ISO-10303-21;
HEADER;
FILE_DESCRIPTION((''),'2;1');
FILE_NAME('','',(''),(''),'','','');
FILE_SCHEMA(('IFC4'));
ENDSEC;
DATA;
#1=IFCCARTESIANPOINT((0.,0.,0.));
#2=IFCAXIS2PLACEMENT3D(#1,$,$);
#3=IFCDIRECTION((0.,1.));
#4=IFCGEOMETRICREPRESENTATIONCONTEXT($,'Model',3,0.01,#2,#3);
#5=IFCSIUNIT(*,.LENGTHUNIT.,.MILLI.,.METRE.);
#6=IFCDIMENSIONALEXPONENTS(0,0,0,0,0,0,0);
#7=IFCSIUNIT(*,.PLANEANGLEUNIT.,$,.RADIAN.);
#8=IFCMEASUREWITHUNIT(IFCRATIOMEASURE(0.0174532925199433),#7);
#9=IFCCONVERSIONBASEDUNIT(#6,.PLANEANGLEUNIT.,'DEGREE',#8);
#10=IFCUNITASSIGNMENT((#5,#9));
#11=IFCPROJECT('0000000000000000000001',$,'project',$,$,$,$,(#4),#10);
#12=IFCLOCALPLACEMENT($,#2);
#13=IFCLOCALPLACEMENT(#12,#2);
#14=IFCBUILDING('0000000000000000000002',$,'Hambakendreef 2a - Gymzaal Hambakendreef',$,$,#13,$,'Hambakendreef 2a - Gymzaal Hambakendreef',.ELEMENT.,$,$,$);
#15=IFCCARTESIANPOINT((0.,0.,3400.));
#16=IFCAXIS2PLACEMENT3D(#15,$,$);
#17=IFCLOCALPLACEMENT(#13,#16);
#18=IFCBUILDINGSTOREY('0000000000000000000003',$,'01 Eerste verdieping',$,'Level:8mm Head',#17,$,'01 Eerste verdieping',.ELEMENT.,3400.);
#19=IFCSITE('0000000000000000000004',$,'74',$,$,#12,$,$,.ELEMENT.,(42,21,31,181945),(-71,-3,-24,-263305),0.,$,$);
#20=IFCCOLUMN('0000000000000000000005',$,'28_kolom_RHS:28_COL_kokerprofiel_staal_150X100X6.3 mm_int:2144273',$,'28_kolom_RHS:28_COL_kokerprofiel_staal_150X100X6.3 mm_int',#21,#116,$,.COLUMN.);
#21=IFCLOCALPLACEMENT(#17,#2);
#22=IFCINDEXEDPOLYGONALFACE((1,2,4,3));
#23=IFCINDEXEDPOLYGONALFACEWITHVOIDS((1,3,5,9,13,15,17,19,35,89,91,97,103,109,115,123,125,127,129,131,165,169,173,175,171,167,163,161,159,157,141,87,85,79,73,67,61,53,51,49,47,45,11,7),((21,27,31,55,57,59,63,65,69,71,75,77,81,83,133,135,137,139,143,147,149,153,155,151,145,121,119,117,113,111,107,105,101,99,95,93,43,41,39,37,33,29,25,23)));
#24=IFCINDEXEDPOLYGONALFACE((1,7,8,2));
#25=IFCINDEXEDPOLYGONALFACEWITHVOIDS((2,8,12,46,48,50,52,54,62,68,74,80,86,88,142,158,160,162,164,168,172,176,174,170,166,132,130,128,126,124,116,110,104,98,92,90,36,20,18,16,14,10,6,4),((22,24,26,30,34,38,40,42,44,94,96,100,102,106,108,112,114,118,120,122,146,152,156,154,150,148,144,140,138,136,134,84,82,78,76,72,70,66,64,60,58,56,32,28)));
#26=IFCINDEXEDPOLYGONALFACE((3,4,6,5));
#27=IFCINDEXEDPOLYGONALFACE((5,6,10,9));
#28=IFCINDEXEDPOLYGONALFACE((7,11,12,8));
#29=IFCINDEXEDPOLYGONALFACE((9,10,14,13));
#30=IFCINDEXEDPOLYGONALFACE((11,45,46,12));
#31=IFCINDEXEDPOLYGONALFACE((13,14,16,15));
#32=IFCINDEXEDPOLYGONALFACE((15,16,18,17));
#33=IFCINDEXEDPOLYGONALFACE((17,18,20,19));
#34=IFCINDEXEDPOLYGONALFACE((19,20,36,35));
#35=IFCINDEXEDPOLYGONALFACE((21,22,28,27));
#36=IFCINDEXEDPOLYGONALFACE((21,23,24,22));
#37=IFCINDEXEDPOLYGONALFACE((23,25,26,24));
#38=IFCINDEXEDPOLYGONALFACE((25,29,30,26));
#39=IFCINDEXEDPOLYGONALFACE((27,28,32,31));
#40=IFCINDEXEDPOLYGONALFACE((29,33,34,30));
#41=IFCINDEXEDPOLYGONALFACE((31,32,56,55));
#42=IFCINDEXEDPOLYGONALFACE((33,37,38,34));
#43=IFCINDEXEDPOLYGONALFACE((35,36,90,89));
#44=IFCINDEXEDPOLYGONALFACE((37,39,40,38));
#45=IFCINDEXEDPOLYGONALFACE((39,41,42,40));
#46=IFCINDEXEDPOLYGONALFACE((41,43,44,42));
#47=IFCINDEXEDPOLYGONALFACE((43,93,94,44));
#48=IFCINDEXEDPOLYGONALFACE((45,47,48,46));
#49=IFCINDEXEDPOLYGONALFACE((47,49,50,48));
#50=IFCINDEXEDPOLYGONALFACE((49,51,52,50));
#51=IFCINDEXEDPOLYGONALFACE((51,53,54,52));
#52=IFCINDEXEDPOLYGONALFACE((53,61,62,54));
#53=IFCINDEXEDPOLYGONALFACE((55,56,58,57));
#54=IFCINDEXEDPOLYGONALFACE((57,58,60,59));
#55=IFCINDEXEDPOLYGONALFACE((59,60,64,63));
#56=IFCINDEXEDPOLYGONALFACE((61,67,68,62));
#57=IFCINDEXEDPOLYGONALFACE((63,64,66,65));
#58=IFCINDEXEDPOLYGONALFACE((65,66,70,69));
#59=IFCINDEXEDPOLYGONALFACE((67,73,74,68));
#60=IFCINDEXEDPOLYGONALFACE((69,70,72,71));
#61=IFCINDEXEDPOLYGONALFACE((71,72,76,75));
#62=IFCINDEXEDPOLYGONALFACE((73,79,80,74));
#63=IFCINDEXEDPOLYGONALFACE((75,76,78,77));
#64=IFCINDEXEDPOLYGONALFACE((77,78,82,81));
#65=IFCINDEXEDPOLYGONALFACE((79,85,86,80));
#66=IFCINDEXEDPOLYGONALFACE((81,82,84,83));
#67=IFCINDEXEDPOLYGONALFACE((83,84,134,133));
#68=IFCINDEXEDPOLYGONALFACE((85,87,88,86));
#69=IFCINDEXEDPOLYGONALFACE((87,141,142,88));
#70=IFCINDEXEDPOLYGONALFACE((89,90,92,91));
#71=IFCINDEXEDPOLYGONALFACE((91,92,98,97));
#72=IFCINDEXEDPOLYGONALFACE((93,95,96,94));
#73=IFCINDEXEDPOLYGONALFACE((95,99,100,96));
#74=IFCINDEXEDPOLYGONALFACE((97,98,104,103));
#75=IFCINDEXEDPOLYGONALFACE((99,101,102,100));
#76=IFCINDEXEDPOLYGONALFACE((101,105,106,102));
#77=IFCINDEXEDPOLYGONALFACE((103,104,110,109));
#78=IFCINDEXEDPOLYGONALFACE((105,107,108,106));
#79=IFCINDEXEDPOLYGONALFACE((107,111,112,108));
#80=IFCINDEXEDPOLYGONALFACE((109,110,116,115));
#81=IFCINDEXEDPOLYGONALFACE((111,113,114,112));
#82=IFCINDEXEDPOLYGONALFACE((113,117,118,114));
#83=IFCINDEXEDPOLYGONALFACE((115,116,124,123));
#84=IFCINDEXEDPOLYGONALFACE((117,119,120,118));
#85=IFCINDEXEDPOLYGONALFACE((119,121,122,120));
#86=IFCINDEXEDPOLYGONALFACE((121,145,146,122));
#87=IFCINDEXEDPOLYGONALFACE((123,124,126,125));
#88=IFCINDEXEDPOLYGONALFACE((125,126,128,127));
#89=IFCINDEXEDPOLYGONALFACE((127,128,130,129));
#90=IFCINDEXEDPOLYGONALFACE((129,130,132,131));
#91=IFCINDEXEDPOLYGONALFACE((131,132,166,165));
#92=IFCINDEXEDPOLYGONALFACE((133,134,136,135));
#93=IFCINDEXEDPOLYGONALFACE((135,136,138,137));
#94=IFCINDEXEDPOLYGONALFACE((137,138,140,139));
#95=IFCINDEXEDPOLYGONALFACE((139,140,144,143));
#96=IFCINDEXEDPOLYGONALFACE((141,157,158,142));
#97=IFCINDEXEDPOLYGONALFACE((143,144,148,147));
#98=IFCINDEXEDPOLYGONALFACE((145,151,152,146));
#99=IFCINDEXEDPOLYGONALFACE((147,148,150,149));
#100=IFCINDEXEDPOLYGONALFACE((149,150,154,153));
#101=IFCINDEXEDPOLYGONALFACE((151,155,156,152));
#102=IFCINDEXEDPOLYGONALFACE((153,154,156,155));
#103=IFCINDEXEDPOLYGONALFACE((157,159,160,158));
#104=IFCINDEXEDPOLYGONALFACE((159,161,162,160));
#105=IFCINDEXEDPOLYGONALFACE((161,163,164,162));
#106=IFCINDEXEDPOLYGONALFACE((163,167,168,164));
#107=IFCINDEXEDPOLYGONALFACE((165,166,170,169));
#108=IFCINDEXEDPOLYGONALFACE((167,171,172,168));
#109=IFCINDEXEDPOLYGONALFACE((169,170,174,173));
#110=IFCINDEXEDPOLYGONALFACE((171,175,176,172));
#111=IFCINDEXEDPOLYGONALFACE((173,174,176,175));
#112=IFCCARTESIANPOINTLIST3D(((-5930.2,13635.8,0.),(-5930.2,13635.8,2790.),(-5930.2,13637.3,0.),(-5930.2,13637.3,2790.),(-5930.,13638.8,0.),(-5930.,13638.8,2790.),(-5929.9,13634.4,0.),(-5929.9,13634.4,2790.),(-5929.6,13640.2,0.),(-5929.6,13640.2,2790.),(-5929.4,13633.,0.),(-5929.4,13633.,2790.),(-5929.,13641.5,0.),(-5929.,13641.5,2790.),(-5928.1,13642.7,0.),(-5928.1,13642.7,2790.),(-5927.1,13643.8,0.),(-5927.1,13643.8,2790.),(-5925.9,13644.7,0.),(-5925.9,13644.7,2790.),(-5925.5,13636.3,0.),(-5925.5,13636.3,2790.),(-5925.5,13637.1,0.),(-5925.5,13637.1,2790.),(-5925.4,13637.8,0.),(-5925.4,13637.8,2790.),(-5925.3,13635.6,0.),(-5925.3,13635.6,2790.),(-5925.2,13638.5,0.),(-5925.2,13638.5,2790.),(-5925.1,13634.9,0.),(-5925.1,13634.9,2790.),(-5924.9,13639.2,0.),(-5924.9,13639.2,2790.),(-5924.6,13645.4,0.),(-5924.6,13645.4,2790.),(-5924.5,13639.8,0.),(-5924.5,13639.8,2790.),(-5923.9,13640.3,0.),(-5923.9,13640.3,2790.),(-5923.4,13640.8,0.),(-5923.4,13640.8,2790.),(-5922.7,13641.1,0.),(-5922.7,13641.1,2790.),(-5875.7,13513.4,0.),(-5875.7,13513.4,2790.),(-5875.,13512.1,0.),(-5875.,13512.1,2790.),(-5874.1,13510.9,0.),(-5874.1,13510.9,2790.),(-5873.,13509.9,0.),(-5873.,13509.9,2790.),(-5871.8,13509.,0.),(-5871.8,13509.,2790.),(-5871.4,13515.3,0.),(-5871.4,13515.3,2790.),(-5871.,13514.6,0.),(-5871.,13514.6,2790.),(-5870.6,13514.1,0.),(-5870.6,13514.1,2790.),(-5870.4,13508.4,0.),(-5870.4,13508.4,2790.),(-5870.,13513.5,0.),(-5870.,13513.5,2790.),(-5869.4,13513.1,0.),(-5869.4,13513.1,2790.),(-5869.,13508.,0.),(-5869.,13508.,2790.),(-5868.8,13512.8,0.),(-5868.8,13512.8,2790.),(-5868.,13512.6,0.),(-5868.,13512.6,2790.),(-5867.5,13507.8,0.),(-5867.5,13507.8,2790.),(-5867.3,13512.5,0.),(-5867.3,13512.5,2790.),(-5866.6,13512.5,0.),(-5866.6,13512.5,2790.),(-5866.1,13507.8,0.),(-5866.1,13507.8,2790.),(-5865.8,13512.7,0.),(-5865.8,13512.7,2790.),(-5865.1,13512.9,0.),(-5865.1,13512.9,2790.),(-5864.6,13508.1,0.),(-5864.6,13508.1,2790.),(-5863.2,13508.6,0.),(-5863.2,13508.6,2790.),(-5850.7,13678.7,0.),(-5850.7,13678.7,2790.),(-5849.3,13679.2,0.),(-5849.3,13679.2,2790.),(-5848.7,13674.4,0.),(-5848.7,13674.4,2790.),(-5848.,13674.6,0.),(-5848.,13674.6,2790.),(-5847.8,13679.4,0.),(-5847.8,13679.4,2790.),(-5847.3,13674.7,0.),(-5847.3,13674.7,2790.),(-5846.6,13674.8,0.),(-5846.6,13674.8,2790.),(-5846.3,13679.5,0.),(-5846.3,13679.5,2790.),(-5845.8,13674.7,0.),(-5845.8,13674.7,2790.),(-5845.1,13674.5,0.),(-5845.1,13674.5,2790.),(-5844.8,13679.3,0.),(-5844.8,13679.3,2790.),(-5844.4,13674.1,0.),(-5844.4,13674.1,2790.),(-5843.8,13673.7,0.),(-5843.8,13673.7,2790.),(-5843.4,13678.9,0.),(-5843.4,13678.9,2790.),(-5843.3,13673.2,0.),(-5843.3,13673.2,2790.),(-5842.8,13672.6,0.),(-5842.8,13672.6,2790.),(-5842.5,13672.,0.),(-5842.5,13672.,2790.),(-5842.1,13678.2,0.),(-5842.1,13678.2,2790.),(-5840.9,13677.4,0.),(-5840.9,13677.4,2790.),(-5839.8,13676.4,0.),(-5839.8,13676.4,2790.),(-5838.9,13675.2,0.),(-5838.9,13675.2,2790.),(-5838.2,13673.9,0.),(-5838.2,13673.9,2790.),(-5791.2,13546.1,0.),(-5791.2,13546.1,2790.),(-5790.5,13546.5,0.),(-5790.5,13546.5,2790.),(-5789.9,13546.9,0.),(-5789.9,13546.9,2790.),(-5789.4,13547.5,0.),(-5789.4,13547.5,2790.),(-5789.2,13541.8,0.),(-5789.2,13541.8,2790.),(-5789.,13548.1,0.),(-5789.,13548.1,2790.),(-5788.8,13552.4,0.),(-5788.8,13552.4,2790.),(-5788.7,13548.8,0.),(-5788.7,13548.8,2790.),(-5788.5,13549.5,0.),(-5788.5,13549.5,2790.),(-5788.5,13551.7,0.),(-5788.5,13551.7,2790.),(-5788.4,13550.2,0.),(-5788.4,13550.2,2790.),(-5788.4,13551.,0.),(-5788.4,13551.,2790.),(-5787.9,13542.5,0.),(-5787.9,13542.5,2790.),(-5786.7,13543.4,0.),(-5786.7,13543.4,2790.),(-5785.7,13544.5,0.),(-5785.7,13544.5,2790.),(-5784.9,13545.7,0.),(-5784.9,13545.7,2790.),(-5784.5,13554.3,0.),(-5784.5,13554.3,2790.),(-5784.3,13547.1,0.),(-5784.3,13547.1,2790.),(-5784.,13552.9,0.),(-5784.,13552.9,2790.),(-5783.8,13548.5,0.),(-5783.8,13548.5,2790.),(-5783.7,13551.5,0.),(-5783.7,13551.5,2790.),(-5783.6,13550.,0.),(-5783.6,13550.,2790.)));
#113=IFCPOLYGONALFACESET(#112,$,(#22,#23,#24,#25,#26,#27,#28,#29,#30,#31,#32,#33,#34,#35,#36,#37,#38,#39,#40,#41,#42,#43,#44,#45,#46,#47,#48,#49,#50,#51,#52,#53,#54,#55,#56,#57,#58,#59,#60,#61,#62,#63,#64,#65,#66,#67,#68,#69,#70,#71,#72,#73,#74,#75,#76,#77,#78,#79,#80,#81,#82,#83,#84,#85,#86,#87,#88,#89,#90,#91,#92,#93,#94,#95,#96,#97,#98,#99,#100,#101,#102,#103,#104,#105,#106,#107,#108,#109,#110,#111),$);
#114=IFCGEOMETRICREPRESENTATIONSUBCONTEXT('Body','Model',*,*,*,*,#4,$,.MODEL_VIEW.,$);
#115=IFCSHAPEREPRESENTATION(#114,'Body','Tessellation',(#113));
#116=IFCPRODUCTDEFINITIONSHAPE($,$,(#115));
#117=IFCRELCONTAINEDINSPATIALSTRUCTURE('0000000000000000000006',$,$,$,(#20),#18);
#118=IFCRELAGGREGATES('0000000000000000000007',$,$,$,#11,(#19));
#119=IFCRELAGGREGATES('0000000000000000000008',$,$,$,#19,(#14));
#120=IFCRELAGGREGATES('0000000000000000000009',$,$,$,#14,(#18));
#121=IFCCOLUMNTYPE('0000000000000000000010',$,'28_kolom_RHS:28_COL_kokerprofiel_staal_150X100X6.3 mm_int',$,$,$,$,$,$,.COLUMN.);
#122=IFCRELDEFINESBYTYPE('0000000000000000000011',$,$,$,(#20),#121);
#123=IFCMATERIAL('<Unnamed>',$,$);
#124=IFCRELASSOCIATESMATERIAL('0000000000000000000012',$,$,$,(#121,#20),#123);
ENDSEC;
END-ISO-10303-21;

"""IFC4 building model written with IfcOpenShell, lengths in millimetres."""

from ifc_helpers import new_model, entity, si_unit, converted_unit, direction, frame, origin, place, context, subcontext, project, spatial, indexed_curve, outline, extrude, source, transform, mapped, material, type_object, type_shapes, element, save


model = new_model("IFC4")

# Units and contexts
model_context = context("Model", 3, precision=0.01, world=origin(), true_north=direction((0.0, 1.0)))
body_context = subcontext(model_context, "Body", "Model", "MODEL_VIEW")
ifc_project = project(units=[si_unit("LENGTHUNIT", "METRE", prefix="MILLI"), converted_unit("PLANEANGLEUNIT", "DEGREE", entity("IfcRatioMeasure", 0.0174532925199433), si_unit("PLANEANGLEUNIT", "RADIAN"), dimensions=[0, 0, 0, 0, 0, 0, 0])], contexts=[model_context])

# Site, building, storey
site_placement = place(None, origin())
site = spatial("IfcSite", under=ifc_project, at=site_placement, Name="74", CompositionType="ELEMENT", RefLatitude=(42, 21, 31, 181945), RefLongitude=(-71, -3, -24, -263305), RefElevation=0.0)
building_placement = place(site_placement, origin())
building = spatial("IfcBuilding", under=site, at=building_placement, Name="Hambakendreef 2a - Gymzaal Hambakendreef", LongName="Hambakendreef 2a - Gymzaal Hambakendreef", CompositionType="ELEMENT")
storey_placement = place(building_placement, frame((0.0, 0.0, 3400.0)))
storey = spatial("IfcBuildingStorey", under=building, at=storey_placement, Name="01 Eerste verdieping", ObjectType="Level:8mm Head", LongName="01 Eerste verdieping", CompositionType="ELEMENT", Elevation=3400.0)

# Column
ifc_material_1 = material(Name="<Unnamed>")
column_type_1 = type_object("IfcColumnType", Name="28_kolom_RHS:28_COL_kokerprofiel_staal_150X100X6.3 mm_int", PredefinedType="COLUMN", material=ifc_material_1)
shared_shape_1 = source(origin(), body_context, "Body", "SweptSolid", [
    extrude(outline(indexed_curve([(-40.5, -75.0), (40.5, -75.0), (42.0, -74.9), (43.5, -74.5), (44.8, -74.0), (46.1, -73.2), (47.2, -72.2), (48.2, -71.1), (49.0, -69.8), (49.5, -68.5), (49.9, -67.0), (50.0, -65.6), (50.0, 65.6), (49.9, 67.0), (49.5, 68.5), (49.0, 69.8), (48.2, 71.1), (47.2, 72.2), (46.1, 73.2), (44.8, 74.0), (43.5, 74.5), (42.0, 74.9), (40.5, 75.0), (-40.5, 75.0), (-42.0, 74.9), (-43.5, 74.5), (-44.8, 74.0), (-46.1, 73.2), (-47.2, 72.2), (-48.2, 71.1), (-49.0, 69.8), (-49.5, 68.5), (-49.9, 67.0), (-50.0, 65.6), (-50.0, -65.6), (-49.9, -67.0), (-49.5, -68.5), (-49.0, -69.8), (-48.2, -71.1), (-47.2, -72.2), (-46.1, -73.2), (-44.8, -74.0), (-43.5, -74.5), (-42.0, -74.9), (-40.5, -75.0)], self_intersect=False), holes=[indexed_curve([(-45.3, 65.5), (-45.2, 66.3), (-45.0, 67.0), (-44.8, 67.7), (-44.4, 68.3), (-43.9, 68.9), (-43.3, 69.4), (-42.7, 69.8), (-42.0, 70.0), (-41.3, 70.2), (-40.6, 70.3), (40.5, 70.3), (41.3, 70.2), (42.0, 70.0), (42.7, 69.8), (43.3, 69.4), (43.9, 68.9), (44.4, 68.3), (44.8, 67.7), (45.0, 67.0), (45.2, 66.3), (45.3, 65.5), (45.3, -65.5), (45.2, -66.3), (45.0, -67.0), (44.8, -67.7), (44.4, -68.3), (43.9, -68.9), (43.3, -69.4), (42.7, -69.8), (42.0, -70.0), (41.3, -70.2), (40.5, -70.3), (-40.6, -70.3), (-41.3, -70.2), (-42.0, -70.0), (-42.7, -69.8), (-43.3, -69.4), (-43.9, -68.9), (-44.4, -68.3), (-44.8, -67.7), (-45.0, -67.0), (-45.2, -66.3), (-45.3, -65.5), (-45.3, 65.5)], self_intersect=False)]), frame((235.6, 34.3, 3400.0), z_axis=(0.0, 0.0, 1.0), x_axis=(0.0, 1.0, 0.0)), (0.0, 0.0, 1.0), 2790.0),
])
type_shapes(column_type_1, [shared_shape_1])
for number, where, z_axis, x_axis, name in (
    (1, (-5984.7, 13794.5, -3400.0), (0.0, 0.0, 1.0), (0.40959, -0.91227, 0.0), "28_kolom_RHS:28_COL_kokerprofiel_staal_150X100X6.3 mm_int:2144273"),
):
    element("IfcColumn", number, at=place(storey_placement, frame(where, z_axis=z_axis, x_axis=x_axis)), inside=storey, type_object=column_type_1, material=ifc_material_1, Name=name, ObjectType="28_kolom_RHS:28_COL_kokerprofiel_staal_150X100X6.3 mm_int", PredefinedType="COLUMN", context=body_context, shape_type="MappedRepresentation", body=[
        mapped(shared_shape_1, transform((0.0, 0.0, 0.0), scale=1.0)),
    ])

save(model, "model.ifc")
